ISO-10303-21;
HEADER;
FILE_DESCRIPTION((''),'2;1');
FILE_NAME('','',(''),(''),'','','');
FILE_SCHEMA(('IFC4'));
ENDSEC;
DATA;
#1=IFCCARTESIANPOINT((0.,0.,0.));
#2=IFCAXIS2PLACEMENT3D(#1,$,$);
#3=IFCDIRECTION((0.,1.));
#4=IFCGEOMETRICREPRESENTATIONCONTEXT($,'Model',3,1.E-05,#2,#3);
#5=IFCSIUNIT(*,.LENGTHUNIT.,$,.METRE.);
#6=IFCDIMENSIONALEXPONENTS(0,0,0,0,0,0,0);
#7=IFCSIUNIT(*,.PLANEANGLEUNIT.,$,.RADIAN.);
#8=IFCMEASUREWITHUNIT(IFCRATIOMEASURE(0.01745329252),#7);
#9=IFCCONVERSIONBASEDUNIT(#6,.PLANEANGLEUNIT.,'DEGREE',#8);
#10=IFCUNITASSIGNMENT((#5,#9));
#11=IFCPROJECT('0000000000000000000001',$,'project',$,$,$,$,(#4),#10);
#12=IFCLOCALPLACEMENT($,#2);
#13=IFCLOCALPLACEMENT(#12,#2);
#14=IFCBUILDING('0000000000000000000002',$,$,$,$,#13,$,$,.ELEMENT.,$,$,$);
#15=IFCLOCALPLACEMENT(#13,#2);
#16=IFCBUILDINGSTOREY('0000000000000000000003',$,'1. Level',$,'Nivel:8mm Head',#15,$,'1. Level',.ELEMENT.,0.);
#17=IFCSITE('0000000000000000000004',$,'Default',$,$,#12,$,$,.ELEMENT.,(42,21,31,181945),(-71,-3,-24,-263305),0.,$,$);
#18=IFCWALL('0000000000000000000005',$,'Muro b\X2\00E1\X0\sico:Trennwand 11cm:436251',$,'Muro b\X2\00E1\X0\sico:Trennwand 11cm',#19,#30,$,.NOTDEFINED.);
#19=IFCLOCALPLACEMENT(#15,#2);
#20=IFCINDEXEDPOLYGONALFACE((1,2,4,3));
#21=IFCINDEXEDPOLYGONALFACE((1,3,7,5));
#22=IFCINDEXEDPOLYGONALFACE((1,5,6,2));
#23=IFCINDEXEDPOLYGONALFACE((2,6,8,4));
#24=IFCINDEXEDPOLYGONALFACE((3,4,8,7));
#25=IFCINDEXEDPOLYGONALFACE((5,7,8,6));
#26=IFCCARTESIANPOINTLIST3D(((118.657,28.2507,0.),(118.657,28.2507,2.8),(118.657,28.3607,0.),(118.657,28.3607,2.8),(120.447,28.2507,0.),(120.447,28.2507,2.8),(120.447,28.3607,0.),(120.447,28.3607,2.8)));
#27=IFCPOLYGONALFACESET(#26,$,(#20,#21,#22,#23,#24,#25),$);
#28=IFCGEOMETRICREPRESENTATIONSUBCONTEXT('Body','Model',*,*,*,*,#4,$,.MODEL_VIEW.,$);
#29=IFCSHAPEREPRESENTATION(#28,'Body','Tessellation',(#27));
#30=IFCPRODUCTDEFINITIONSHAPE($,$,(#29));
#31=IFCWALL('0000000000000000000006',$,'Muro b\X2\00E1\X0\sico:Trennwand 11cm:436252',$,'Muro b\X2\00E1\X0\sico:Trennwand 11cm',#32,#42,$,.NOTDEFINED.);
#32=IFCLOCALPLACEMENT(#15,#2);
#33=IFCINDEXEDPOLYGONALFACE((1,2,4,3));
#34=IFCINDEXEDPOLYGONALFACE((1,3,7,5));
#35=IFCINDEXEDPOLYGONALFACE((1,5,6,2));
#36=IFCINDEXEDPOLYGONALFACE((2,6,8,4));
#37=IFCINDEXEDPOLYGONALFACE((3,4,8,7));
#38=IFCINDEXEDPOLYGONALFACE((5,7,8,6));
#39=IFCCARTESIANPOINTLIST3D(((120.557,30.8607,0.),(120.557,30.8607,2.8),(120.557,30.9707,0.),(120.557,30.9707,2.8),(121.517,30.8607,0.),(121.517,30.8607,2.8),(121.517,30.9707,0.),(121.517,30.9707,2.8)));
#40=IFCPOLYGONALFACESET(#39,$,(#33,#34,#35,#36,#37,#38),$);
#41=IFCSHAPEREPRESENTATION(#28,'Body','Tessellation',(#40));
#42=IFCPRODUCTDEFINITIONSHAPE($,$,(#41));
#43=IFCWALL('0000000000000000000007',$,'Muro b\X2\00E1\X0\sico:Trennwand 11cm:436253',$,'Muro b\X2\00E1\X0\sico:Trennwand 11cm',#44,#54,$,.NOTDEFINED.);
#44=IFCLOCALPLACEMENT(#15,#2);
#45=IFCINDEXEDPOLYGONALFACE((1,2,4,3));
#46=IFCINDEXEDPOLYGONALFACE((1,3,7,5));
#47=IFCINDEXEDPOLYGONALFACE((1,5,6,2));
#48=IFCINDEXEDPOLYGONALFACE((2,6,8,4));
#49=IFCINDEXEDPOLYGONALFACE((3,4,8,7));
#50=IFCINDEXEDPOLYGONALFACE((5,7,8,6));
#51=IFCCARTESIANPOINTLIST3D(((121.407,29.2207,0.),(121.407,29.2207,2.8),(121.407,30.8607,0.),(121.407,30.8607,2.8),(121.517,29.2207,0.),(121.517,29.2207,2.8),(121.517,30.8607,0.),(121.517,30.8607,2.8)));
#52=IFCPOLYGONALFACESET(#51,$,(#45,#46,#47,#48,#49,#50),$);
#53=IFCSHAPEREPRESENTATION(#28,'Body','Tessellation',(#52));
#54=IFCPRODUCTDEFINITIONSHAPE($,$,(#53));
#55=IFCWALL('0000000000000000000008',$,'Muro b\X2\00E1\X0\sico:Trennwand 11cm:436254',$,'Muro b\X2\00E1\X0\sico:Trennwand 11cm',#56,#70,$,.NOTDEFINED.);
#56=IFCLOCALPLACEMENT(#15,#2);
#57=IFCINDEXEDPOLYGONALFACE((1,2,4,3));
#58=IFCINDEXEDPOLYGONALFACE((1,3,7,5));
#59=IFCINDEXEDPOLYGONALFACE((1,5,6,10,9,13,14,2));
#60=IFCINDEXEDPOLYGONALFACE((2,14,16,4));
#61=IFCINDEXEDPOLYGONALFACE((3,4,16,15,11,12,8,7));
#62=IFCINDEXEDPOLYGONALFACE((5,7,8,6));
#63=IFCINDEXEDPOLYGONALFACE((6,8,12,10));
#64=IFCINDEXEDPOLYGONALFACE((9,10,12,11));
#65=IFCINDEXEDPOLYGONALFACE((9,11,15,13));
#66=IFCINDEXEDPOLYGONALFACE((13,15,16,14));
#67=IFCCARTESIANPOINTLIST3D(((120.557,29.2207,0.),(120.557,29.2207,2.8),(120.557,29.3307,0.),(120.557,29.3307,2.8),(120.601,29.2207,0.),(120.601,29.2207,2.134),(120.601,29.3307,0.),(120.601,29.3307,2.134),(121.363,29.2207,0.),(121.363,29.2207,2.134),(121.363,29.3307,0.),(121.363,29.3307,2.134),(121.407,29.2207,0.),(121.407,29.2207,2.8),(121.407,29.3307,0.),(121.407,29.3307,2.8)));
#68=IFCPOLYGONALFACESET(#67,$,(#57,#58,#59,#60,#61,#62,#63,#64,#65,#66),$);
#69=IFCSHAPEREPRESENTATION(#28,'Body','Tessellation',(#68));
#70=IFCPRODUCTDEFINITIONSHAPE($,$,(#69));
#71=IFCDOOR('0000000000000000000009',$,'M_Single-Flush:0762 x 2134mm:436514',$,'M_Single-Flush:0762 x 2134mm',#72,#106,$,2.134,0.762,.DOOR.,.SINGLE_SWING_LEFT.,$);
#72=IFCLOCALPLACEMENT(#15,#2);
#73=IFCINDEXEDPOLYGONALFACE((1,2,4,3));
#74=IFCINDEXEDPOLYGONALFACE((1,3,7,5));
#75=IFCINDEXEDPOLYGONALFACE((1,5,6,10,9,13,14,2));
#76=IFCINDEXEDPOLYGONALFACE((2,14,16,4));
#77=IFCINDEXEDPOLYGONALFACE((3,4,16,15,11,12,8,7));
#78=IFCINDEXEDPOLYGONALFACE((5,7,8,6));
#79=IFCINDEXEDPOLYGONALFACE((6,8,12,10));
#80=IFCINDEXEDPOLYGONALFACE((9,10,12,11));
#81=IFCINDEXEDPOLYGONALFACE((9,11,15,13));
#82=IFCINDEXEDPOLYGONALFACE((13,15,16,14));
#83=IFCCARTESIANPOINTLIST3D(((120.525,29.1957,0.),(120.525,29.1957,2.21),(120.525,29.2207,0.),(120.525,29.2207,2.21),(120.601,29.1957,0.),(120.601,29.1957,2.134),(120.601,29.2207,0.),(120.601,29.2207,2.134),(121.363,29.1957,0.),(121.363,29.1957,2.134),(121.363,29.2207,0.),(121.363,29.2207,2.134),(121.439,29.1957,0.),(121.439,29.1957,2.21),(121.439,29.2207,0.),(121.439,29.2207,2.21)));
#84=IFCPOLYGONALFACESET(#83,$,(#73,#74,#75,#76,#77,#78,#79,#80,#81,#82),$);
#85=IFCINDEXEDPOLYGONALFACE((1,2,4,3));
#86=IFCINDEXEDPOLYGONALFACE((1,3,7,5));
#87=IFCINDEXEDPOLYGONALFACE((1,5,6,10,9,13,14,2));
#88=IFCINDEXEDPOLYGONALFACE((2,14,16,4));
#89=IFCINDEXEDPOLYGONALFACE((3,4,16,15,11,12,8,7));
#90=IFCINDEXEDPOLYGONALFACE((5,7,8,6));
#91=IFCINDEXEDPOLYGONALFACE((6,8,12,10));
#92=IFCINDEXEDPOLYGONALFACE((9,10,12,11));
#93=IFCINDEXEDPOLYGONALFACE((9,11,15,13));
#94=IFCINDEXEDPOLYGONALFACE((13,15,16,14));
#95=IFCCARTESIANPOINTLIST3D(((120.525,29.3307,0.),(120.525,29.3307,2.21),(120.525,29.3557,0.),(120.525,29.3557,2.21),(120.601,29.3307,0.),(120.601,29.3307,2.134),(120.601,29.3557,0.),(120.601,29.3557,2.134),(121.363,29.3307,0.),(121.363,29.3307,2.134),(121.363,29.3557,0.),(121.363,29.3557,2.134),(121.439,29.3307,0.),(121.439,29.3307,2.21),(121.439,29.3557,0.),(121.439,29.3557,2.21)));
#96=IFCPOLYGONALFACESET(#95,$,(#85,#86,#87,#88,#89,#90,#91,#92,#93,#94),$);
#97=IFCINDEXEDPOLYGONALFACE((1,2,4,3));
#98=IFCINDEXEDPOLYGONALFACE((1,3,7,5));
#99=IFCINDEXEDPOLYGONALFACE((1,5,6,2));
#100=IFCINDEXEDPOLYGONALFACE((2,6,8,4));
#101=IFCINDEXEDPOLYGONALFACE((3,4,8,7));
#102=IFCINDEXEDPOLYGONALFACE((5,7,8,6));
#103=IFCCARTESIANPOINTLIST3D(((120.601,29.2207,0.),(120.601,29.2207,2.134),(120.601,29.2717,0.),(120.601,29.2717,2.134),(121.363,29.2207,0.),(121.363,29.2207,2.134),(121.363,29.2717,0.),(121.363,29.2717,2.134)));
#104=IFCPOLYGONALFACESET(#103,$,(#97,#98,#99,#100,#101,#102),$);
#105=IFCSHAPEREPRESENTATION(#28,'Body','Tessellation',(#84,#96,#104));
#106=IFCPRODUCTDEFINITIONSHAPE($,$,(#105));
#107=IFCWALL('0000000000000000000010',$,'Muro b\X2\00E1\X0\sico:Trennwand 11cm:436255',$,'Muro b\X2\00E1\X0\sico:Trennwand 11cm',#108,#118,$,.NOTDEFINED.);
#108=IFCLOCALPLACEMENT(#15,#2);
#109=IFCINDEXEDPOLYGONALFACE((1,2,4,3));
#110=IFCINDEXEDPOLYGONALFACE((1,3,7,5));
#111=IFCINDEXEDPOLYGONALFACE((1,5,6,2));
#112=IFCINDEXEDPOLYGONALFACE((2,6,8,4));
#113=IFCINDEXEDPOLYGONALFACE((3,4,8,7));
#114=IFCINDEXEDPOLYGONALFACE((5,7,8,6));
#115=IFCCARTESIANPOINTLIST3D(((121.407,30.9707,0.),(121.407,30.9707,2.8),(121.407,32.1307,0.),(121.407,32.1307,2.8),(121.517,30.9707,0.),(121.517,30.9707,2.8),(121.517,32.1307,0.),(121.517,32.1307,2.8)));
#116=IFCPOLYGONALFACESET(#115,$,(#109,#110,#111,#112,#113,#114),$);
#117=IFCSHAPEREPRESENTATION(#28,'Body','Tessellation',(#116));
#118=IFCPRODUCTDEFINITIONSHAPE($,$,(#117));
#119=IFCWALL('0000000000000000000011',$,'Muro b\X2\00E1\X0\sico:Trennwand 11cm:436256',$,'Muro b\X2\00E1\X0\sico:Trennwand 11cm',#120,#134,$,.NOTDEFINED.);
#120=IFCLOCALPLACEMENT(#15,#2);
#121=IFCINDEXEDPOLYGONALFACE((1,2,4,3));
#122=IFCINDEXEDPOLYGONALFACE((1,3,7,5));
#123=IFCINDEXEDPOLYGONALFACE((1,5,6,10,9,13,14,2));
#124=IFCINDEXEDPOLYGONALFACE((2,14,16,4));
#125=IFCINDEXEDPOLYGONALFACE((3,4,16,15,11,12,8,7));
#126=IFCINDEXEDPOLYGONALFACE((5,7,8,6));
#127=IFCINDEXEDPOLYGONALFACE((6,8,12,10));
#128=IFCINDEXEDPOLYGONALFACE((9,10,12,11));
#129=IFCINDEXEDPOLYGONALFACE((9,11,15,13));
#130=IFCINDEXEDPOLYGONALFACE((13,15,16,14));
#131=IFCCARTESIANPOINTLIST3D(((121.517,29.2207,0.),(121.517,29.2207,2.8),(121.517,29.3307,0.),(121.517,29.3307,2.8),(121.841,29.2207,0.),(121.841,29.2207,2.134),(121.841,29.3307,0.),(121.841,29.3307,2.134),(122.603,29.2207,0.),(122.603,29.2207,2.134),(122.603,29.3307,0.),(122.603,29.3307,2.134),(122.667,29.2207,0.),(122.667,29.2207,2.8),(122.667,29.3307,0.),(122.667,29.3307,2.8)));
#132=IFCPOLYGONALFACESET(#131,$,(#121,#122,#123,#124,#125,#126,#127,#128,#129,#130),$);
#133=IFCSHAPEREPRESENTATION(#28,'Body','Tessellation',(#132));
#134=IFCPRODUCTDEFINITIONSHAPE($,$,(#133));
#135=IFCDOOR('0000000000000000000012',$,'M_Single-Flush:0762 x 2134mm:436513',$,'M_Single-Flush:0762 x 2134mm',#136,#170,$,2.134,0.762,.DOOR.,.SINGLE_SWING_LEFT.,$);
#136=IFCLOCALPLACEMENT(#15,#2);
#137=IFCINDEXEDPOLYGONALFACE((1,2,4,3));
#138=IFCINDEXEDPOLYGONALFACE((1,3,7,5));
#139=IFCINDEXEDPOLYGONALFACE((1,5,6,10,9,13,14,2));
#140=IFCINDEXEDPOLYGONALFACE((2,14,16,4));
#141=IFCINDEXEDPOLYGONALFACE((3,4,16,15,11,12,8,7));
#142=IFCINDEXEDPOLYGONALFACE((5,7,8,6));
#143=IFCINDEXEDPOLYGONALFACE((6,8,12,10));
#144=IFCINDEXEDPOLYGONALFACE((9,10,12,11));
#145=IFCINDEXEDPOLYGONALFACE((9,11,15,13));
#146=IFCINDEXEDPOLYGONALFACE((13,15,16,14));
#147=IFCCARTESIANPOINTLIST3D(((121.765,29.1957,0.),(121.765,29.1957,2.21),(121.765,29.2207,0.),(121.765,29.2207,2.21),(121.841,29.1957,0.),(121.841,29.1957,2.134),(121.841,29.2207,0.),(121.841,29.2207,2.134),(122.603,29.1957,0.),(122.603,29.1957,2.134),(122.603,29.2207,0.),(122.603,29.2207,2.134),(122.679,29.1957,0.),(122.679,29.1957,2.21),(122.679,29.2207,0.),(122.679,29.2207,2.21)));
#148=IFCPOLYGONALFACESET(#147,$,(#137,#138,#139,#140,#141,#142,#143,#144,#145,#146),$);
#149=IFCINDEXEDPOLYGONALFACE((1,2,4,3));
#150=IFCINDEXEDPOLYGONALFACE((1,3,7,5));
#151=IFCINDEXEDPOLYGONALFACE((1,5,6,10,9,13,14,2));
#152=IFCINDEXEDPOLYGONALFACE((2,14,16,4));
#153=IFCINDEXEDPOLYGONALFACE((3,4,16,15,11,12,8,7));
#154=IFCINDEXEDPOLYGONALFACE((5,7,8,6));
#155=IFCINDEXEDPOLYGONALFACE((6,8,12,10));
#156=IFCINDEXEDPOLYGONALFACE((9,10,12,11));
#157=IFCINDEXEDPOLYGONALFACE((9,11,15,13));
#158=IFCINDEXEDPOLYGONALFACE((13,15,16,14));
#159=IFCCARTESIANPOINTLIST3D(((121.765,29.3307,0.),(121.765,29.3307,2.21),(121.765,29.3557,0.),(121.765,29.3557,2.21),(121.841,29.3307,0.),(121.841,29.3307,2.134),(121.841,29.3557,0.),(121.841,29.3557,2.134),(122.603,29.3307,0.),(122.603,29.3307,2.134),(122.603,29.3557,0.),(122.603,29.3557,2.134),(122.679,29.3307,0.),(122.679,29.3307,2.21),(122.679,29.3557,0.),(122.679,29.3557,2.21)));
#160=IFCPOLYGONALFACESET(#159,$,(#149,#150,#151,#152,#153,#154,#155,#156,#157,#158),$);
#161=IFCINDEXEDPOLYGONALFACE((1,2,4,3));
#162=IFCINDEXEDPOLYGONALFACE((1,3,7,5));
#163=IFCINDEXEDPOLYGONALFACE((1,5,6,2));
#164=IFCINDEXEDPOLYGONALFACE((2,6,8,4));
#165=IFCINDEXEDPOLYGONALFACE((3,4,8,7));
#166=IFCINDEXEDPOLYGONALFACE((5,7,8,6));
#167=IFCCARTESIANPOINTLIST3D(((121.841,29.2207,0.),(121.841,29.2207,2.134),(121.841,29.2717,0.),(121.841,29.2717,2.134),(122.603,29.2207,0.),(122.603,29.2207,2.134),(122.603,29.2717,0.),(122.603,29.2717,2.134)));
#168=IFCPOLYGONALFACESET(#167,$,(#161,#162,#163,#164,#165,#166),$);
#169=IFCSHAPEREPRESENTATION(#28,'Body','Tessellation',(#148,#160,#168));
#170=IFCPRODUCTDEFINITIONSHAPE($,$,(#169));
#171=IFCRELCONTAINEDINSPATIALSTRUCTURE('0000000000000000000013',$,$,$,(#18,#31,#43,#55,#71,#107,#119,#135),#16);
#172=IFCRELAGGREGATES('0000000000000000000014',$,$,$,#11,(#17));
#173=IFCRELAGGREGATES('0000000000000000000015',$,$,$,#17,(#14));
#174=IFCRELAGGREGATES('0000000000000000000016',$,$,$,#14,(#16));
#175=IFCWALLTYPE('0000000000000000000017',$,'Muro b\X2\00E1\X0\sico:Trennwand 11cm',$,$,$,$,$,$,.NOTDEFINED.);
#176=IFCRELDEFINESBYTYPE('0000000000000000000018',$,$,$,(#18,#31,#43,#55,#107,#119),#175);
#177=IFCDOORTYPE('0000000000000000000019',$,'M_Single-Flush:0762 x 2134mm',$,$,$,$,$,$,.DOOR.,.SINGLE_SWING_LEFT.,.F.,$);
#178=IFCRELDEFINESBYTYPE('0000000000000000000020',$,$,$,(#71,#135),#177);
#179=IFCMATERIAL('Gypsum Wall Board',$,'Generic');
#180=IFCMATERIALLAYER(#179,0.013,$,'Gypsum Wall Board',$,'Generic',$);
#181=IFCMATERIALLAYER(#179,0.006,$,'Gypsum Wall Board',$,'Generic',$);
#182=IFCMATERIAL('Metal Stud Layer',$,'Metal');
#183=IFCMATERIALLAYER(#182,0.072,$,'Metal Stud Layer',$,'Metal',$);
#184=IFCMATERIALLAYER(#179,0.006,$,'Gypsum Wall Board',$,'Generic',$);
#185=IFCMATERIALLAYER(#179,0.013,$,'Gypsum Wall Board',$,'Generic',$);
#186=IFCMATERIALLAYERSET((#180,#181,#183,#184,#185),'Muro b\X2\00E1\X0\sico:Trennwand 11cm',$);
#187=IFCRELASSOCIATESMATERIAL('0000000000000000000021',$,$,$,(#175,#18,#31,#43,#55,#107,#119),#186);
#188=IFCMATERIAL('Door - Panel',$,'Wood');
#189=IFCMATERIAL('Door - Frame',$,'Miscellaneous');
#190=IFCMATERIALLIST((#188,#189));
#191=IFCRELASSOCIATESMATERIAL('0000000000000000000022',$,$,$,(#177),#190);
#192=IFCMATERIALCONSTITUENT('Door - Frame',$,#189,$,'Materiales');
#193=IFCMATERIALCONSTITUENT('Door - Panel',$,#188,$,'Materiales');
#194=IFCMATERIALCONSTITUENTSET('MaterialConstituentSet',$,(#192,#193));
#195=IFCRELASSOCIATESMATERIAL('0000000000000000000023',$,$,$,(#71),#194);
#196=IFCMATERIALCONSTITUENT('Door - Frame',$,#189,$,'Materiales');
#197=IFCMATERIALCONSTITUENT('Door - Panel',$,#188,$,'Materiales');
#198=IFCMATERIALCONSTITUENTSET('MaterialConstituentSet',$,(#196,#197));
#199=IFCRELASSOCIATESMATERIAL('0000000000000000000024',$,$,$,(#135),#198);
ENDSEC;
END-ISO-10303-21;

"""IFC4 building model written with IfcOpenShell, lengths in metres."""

from ifc_helpers import new_model, entity, si_unit, converted_unit, direction, frame, frame_2d, origin, origin_2d_with_axis, place, context, subcontext, project, spatial, polyline, rectangle, outline, extrude, source, transform, mapped, material, material_list, layer, layer_set, layer_usage, constituent, constituent_set, type_object, type_shapes, element, fill, save


model = new_model("IFC4")

# Units and contexts
model_context = context("Model", 3, precision=1e-05, world=origin(), true_north=direction((0.0, 1.0)))
body_context = subcontext(model_context, "Body", "Model", "MODEL_VIEW")
ifc_project = project(units=[si_unit("LENGTHUNIT", "METRE"), converted_unit("PLANEANGLEUNIT", "DEGREE", entity("IfcRatioMeasure", 0.01745329252), si_unit("PLANEANGLEUNIT", "RADIAN"), dimensions=[0, 0, 0, 0, 0, 0, 0])], contexts=[model_context])

# Site, building, storey
site_placement = place(None, origin())
site = spatial("IfcSite", under=ifc_project, at=site_placement, Name="Default", CompositionType="ELEMENT", RefLatitude=(42, 21, 31, 181945), RefLongitude=(-71, -3, -24, -263305), RefElevation=0.0)
building_placement = place(site_placement, origin())
building = spatial("IfcBuilding", under=site, at=building_placement, CompositionType="ELEMENT")
storey_placement = place(building_placement, origin())
storey = spatial("IfcBuildingStorey", under=building, at=storey_placement, Name="1. Level", ObjectType="Nivel:8mm Head", LongName="1. Level", CompositionType="ELEMENT", Elevation=0.0)

# Shared definitions
ifc_material_1 = material(Name="Gypsum Wall Board", Category="Generic")
ifc_layer_1 = layer(ifc_material_1, 0.013, Name="Gypsum Wall Board", Category="Generic")
ifc_layer_2 = layer(ifc_material_1, 0.006, Name="Gypsum Wall Board", Category="Generic")
ifc_material_2 = material(Name="Metal Stud Layer", Category="Metal")
ifc_layer_3 = layer(ifc_material_2, 0.072, Name="Metal Stud Layer", Category="Metal")
ifc_layer_4 = layer(ifc_material_1, 0.006, Name="Gypsum Wall Board", Category="Generic")
ifc_layer_5 = layer(ifc_material_1, 0.013, Name="Gypsum Wall Board", Category="Generic")
ifc_layer_set_1 = layer_set([ifc_layer_1, ifc_layer_2, ifc_layer_3, ifc_layer_4, ifc_layer_5], Name="Muro básico:Trennwand 11cm")
wall_type_1 = type_object("IfcWallType", Name="Muro básico:Trennwand 11cm", PredefinedType="NOTDEFINED", material=ifc_layer_set_1)
ifc_material_3 = material(Name="Door - Frame", Category="Miscellaneous")
ifc_material_4 = material(Name="Door - Panel", Category="Wood")
ifc_material_list_1 = material_list([ifc_material_4, ifc_material_3])
door_type_1 = type_object("IfcDoorType", Name="M_Single-Flush:0762 x 2134mm", OperationType="SINGLE_SWING_LEFT", ParameterTakesPrecedence=False, PredefinedType="DOOR", material=ifc_material_list_1)
shared_shape_1 = source(origin(), body_context, "Body", "SweptSolid", [
    extrude(outline(polyline([(-0.457, -1.124), (0.457, -1.124), (0.457, 1.086), (0.381, 1.086), (0.381, -1.048), (-0.381, -1.048), (-0.381, 1.086), (-0.457, 1.086), (-0.457, -1.124)])), frame((0.381, 0.135, 1.086), z_axis=(0.0, -1.0, 0.0), x_axis=(-1.0, 0.0, 0.0)), (0.0, 0.0, 1.0), 0.025),
    extrude(outline(polyline([(-1.124, -0.457), (1.086, -0.457), (1.086, -0.381), (-1.048, -0.381), (-1.048, 0.381), (1.086, 0.381), (1.086, 0.457), (-1.124, 0.457), (-1.124, -0.457)])), frame((0.381, 0.0, 1.086), z_axis=(0.0, -1.0, 0.0), x_axis=(0.0, 0.0, -1.0)), (0.0, 0.0, 1.0), 0.025),
    extrude(rectangle(XDim=0.762, YDim=0.051, at=origin_2d_with_axis()), frame((0.381, 0.0845, 0.0)), (0.0, 0.0, 1.0), 2.134),
])
type_shapes(door_type_1, [shared_shape_1])

# Walls
ifc_layer_usage_1 = layer_usage(ifc_layer_set_1, "AXIS2", "NEGATIVE", 0.055)
wall_1_placement = place(storey_placement, frame((120.447, 28.3057, 0.0), z_axis=(0.0, 0.0, 1.0), x_axis=(-1.0, 0.0, 0.0)))
element("IfcWall", 1, at=wall_1_placement, inside=storey, type_object=wall_type_1, material=ifc_layer_usage_1, Name="Muro básico:Trennwand 11cm:436251", ObjectType="Muro básico:Trennwand 11cm", PredefinedType="NOTDEFINED", context=body_context, shape_type="SweptSolid", body=[
    extrude(rectangle(XDim=1.79, YDim=0.11, at=frame_2d((0.895, 0.0), x_axis=(-1.0, 0.0))), origin(), (0.0, 0.0, 1.0), 2.8),
])
ifc_layer_usage_2 = layer_usage(ifc_layer_set_1, "AXIS2", "NEGATIVE", 0.055)
wall_2_placement = place(storey_placement, frame((120.557, 30.9157, 0.0)))
element("IfcWall", 2, at=wall_2_placement, inside=storey, type_object=wall_type_1, material=ifc_layer_usage_2, Name="Muro básico:Trennwand 11cm:436252", ObjectType="Muro básico:Trennwand 11cm", PredefinedType="NOTDEFINED", context=body_context, shape_type="SweptSolid", body=[
    extrude(rectangle(XDim=0.96, YDim=0.11, at=frame_2d((0.48, 0.0), x_axis=(-1.0, 0.0))), origin(), (0.0, 0.0, 1.0), 2.8),
])
ifc_layer_usage_3 = layer_usage(ifc_layer_set_1, "AXIS2", "NEGATIVE", 0.055)
wall_3_placement = place(storey_placement, frame((121.462, 30.8607, 0.0), z_axis=(0.0, 0.0, 1.0), x_axis=(0.0, -1.0, 0.0)))
element("IfcWall", 3, at=wall_3_placement, inside=storey, type_object=wall_type_1, material=ifc_layer_usage_3, Name="Muro básico:Trennwand 11cm:436253", ObjectType="Muro básico:Trennwand 11cm", PredefinedType="NOTDEFINED", context=body_context, shape_type="SweptSolid", body=[
    extrude(rectangle(XDim=1.64, YDim=0.11, at=frame_2d((0.82, 0.0), x_axis=(-1.0, 0.0))), origin(), (0.0, 0.0, 1.0), 2.8),
])

# Wall, opening, door
ifc_layer_usage_4 = layer_usage(ifc_layer_set_1, "AXIS2", "NEGATIVE", 0.055)
wall_4_placement = place(storey_placement, frame((121.407, 29.2757, 0.0), z_axis=(0.0, 0.0, 1.0), x_axis=(-1.0, 0.0, 0.0)))
wall_4 = element("IfcWall", 4, at=wall_4_placement, inside=storey, type_object=wall_type_1, material=ifc_layer_usage_4, Name="Muro básico:Trennwand 11cm:436254", ObjectType="Muro básico:Trennwand 11cm", PredefinedType="NOTDEFINED", context=body_context, shape_type="SweptSolid", body=[
    extrude(rectangle(XDim=0.85, YDim=0.11, at=frame_2d((0.425, 0.0), x_axis=(-1.0, 0.0))), origin(), (0.0, 0.0, 1.0), 2.8),
])
opening_1_placement = place(wall_4_placement, frame((0.044, -0.055, 0.0)))
opening_1 = element("IfcOpeningElement", 5, at=opening_1_placement, cuts=wall_4, ObjectType="Opening", PredefinedType="OPENING", context=body_context, shape_type="SweptSolid", body=[
    extrude(rectangle(XDim=0.762, YDim=2.134, at=frame_2d((1.067, 0.381), x_axis=(0.0, -1.0))), frame((0.0, 0.0, 0.0), z_axis=(0.0, 1.0, 0.0), x_axis=(0.0, 0.0, 1.0)), (0.0, 0.0, 1.0), 0.11),
])
ifc_constituent_1 = constituent(ifc_material_3, Name="Door - Frame", Category="Materiales")
ifc_constituent_2 = constituent(ifc_material_4, Name="Door - Panel", Category="Materiales")
ifc_constituent_set_1 = constituent_set(constituents=[ifc_constituent_1, ifc_constituent_2], Name="MaterialConstituentSet")
door_1_placement = place(opening_1_placement, origin())
door_1 = element("IfcDoor", 6, at=door_1_placement, inside=storey, type_object=door_type_1, material=ifc_constituent_set_1, Name="M_Single-Flush:0762 x 2134mm:436514", ObjectType="M_Single-Flush:0762 x 2134mm", OperationType="SINGLE_SWING_LEFT", OverallHeight=2.134, OverallWidth=0.762, PredefinedType="DOOR", context=body_context, shape_type="MappedRepresentation", body=[
    mapped(shared_shape_1, transform((0.0, 0.0, 0.0), scale=1.0)),
])
fill(opening_1, door_1)

# Wall
ifc_layer_usage_5 = layer_usage(ifc_layer_set_1, "AXIS2", "NEGATIVE", 0.055)
wall_5_placement = place(storey_placement, frame((121.462, 30.9707, 0.0), z_axis=(0.0, 0.0, 1.0), x_axis=(0.0, 1.0, 0.0)))
element("IfcWall", 7, at=wall_5_placement, inside=storey, type_object=wall_type_1, material=ifc_layer_usage_5, Name="Muro básico:Trennwand 11cm:436255", ObjectType="Muro básico:Trennwand 11cm", PredefinedType="NOTDEFINED", context=body_context, shape_type="SweptSolid", body=[
    extrude(rectangle(XDim=1.16, YDim=0.11, at=frame_2d((0.58, 0.0), x_axis=(-1.0, 0.0))), origin(), (0.0, 0.0, 1.0), 2.8),
])

# Wall, opening, door
ifc_layer_usage_6 = layer_usage(ifc_layer_set_1, "AXIS2", "NEGATIVE", 0.055)
wall_6_placement = place(storey_placement, frame((121.517, 29.2757, 0.0)))
wall_6 = element("IfcWall", 8, at=wall_6_placement, inside=storey, type_object=wall_type_1, material=ifc_layer_usage_6, Name="Muro básico:Trennwand 11cm:436256", ObjectType="Muro básico:Trennwand 11cm", PredefinedType="NOTDEFINED", context=body_context, shape_type="SweptSolid", body=[
    extrude(rectangle(XDim=1.15, YDim=0.11, at=frame_2d((0.575, 0.0), x_axis=(-1.0, 0.0))), origin(), (0.0, 0.0, 1.0), 2.8),
])
opening_2_placement = place(wall_6_placement, frame((1.086, 0.055, 0.0)))
opening_2 = element("IfcOpeningElement", 9, at=opening_2_placement, cuts=wall_6, ObjectType="Opening", PredefinedType="OPENING", context=body_context, shape_type="SweptSolid", body=[
    extrude(rectangle(XDim=0.762, YDim=2.134, at=frame_2d((1.067, 0.381), x_axis=(0.0, -1.0))), frame((0.0, 0.0, 0.0), z_axis=(0.0, -1.0, 0.0), x_axis=(0.0, 0.0, 1.0)), (0.0, 0.0, 1.0), 0.11),
])
ifc_constituent_3 = constituent(ifc_material_3, Name="Door - Frame", Category="Materiales")
ifc_constituent_4 = constituent(ifc_material_4, Name="Door - Panel", Category="Materiales")
ifc_constituent_set_2 = constituent_set(constituents=[ifc_constituent_3, ifc_constituent_4], Name="MaterialConstituentSet")
door_2_placement = place(opening_2_placement, frame((0.0, 0.0, 0.0), z_axis=(0.0, 0.0, 1.0), x_axis=(-1.0, 0.0, 0.0)))
door_2 = element("IfcDoor", 10, at=door_2_placement, inside=storey, type_object=door_type_1, material=ifc_constituent_set_2, Name="M_Single-Flush:0762 x 2134mm:436513", ObjectType="M_Single-Flush:0762 x 2134mm", OperationType="SINGLE_SWING_LEFT", OverallHeight=2.134, OverallWidth=0.762, PredefinedType="DOOR", context=body_context, shape_type="MappedRepresentation", body=[
    mapped(shared_shape_1, transform((0.0, 0.0, 0.0), scale=1.0)),
])
fill(opening_2, door_2)

save(model, "model.ifc")
